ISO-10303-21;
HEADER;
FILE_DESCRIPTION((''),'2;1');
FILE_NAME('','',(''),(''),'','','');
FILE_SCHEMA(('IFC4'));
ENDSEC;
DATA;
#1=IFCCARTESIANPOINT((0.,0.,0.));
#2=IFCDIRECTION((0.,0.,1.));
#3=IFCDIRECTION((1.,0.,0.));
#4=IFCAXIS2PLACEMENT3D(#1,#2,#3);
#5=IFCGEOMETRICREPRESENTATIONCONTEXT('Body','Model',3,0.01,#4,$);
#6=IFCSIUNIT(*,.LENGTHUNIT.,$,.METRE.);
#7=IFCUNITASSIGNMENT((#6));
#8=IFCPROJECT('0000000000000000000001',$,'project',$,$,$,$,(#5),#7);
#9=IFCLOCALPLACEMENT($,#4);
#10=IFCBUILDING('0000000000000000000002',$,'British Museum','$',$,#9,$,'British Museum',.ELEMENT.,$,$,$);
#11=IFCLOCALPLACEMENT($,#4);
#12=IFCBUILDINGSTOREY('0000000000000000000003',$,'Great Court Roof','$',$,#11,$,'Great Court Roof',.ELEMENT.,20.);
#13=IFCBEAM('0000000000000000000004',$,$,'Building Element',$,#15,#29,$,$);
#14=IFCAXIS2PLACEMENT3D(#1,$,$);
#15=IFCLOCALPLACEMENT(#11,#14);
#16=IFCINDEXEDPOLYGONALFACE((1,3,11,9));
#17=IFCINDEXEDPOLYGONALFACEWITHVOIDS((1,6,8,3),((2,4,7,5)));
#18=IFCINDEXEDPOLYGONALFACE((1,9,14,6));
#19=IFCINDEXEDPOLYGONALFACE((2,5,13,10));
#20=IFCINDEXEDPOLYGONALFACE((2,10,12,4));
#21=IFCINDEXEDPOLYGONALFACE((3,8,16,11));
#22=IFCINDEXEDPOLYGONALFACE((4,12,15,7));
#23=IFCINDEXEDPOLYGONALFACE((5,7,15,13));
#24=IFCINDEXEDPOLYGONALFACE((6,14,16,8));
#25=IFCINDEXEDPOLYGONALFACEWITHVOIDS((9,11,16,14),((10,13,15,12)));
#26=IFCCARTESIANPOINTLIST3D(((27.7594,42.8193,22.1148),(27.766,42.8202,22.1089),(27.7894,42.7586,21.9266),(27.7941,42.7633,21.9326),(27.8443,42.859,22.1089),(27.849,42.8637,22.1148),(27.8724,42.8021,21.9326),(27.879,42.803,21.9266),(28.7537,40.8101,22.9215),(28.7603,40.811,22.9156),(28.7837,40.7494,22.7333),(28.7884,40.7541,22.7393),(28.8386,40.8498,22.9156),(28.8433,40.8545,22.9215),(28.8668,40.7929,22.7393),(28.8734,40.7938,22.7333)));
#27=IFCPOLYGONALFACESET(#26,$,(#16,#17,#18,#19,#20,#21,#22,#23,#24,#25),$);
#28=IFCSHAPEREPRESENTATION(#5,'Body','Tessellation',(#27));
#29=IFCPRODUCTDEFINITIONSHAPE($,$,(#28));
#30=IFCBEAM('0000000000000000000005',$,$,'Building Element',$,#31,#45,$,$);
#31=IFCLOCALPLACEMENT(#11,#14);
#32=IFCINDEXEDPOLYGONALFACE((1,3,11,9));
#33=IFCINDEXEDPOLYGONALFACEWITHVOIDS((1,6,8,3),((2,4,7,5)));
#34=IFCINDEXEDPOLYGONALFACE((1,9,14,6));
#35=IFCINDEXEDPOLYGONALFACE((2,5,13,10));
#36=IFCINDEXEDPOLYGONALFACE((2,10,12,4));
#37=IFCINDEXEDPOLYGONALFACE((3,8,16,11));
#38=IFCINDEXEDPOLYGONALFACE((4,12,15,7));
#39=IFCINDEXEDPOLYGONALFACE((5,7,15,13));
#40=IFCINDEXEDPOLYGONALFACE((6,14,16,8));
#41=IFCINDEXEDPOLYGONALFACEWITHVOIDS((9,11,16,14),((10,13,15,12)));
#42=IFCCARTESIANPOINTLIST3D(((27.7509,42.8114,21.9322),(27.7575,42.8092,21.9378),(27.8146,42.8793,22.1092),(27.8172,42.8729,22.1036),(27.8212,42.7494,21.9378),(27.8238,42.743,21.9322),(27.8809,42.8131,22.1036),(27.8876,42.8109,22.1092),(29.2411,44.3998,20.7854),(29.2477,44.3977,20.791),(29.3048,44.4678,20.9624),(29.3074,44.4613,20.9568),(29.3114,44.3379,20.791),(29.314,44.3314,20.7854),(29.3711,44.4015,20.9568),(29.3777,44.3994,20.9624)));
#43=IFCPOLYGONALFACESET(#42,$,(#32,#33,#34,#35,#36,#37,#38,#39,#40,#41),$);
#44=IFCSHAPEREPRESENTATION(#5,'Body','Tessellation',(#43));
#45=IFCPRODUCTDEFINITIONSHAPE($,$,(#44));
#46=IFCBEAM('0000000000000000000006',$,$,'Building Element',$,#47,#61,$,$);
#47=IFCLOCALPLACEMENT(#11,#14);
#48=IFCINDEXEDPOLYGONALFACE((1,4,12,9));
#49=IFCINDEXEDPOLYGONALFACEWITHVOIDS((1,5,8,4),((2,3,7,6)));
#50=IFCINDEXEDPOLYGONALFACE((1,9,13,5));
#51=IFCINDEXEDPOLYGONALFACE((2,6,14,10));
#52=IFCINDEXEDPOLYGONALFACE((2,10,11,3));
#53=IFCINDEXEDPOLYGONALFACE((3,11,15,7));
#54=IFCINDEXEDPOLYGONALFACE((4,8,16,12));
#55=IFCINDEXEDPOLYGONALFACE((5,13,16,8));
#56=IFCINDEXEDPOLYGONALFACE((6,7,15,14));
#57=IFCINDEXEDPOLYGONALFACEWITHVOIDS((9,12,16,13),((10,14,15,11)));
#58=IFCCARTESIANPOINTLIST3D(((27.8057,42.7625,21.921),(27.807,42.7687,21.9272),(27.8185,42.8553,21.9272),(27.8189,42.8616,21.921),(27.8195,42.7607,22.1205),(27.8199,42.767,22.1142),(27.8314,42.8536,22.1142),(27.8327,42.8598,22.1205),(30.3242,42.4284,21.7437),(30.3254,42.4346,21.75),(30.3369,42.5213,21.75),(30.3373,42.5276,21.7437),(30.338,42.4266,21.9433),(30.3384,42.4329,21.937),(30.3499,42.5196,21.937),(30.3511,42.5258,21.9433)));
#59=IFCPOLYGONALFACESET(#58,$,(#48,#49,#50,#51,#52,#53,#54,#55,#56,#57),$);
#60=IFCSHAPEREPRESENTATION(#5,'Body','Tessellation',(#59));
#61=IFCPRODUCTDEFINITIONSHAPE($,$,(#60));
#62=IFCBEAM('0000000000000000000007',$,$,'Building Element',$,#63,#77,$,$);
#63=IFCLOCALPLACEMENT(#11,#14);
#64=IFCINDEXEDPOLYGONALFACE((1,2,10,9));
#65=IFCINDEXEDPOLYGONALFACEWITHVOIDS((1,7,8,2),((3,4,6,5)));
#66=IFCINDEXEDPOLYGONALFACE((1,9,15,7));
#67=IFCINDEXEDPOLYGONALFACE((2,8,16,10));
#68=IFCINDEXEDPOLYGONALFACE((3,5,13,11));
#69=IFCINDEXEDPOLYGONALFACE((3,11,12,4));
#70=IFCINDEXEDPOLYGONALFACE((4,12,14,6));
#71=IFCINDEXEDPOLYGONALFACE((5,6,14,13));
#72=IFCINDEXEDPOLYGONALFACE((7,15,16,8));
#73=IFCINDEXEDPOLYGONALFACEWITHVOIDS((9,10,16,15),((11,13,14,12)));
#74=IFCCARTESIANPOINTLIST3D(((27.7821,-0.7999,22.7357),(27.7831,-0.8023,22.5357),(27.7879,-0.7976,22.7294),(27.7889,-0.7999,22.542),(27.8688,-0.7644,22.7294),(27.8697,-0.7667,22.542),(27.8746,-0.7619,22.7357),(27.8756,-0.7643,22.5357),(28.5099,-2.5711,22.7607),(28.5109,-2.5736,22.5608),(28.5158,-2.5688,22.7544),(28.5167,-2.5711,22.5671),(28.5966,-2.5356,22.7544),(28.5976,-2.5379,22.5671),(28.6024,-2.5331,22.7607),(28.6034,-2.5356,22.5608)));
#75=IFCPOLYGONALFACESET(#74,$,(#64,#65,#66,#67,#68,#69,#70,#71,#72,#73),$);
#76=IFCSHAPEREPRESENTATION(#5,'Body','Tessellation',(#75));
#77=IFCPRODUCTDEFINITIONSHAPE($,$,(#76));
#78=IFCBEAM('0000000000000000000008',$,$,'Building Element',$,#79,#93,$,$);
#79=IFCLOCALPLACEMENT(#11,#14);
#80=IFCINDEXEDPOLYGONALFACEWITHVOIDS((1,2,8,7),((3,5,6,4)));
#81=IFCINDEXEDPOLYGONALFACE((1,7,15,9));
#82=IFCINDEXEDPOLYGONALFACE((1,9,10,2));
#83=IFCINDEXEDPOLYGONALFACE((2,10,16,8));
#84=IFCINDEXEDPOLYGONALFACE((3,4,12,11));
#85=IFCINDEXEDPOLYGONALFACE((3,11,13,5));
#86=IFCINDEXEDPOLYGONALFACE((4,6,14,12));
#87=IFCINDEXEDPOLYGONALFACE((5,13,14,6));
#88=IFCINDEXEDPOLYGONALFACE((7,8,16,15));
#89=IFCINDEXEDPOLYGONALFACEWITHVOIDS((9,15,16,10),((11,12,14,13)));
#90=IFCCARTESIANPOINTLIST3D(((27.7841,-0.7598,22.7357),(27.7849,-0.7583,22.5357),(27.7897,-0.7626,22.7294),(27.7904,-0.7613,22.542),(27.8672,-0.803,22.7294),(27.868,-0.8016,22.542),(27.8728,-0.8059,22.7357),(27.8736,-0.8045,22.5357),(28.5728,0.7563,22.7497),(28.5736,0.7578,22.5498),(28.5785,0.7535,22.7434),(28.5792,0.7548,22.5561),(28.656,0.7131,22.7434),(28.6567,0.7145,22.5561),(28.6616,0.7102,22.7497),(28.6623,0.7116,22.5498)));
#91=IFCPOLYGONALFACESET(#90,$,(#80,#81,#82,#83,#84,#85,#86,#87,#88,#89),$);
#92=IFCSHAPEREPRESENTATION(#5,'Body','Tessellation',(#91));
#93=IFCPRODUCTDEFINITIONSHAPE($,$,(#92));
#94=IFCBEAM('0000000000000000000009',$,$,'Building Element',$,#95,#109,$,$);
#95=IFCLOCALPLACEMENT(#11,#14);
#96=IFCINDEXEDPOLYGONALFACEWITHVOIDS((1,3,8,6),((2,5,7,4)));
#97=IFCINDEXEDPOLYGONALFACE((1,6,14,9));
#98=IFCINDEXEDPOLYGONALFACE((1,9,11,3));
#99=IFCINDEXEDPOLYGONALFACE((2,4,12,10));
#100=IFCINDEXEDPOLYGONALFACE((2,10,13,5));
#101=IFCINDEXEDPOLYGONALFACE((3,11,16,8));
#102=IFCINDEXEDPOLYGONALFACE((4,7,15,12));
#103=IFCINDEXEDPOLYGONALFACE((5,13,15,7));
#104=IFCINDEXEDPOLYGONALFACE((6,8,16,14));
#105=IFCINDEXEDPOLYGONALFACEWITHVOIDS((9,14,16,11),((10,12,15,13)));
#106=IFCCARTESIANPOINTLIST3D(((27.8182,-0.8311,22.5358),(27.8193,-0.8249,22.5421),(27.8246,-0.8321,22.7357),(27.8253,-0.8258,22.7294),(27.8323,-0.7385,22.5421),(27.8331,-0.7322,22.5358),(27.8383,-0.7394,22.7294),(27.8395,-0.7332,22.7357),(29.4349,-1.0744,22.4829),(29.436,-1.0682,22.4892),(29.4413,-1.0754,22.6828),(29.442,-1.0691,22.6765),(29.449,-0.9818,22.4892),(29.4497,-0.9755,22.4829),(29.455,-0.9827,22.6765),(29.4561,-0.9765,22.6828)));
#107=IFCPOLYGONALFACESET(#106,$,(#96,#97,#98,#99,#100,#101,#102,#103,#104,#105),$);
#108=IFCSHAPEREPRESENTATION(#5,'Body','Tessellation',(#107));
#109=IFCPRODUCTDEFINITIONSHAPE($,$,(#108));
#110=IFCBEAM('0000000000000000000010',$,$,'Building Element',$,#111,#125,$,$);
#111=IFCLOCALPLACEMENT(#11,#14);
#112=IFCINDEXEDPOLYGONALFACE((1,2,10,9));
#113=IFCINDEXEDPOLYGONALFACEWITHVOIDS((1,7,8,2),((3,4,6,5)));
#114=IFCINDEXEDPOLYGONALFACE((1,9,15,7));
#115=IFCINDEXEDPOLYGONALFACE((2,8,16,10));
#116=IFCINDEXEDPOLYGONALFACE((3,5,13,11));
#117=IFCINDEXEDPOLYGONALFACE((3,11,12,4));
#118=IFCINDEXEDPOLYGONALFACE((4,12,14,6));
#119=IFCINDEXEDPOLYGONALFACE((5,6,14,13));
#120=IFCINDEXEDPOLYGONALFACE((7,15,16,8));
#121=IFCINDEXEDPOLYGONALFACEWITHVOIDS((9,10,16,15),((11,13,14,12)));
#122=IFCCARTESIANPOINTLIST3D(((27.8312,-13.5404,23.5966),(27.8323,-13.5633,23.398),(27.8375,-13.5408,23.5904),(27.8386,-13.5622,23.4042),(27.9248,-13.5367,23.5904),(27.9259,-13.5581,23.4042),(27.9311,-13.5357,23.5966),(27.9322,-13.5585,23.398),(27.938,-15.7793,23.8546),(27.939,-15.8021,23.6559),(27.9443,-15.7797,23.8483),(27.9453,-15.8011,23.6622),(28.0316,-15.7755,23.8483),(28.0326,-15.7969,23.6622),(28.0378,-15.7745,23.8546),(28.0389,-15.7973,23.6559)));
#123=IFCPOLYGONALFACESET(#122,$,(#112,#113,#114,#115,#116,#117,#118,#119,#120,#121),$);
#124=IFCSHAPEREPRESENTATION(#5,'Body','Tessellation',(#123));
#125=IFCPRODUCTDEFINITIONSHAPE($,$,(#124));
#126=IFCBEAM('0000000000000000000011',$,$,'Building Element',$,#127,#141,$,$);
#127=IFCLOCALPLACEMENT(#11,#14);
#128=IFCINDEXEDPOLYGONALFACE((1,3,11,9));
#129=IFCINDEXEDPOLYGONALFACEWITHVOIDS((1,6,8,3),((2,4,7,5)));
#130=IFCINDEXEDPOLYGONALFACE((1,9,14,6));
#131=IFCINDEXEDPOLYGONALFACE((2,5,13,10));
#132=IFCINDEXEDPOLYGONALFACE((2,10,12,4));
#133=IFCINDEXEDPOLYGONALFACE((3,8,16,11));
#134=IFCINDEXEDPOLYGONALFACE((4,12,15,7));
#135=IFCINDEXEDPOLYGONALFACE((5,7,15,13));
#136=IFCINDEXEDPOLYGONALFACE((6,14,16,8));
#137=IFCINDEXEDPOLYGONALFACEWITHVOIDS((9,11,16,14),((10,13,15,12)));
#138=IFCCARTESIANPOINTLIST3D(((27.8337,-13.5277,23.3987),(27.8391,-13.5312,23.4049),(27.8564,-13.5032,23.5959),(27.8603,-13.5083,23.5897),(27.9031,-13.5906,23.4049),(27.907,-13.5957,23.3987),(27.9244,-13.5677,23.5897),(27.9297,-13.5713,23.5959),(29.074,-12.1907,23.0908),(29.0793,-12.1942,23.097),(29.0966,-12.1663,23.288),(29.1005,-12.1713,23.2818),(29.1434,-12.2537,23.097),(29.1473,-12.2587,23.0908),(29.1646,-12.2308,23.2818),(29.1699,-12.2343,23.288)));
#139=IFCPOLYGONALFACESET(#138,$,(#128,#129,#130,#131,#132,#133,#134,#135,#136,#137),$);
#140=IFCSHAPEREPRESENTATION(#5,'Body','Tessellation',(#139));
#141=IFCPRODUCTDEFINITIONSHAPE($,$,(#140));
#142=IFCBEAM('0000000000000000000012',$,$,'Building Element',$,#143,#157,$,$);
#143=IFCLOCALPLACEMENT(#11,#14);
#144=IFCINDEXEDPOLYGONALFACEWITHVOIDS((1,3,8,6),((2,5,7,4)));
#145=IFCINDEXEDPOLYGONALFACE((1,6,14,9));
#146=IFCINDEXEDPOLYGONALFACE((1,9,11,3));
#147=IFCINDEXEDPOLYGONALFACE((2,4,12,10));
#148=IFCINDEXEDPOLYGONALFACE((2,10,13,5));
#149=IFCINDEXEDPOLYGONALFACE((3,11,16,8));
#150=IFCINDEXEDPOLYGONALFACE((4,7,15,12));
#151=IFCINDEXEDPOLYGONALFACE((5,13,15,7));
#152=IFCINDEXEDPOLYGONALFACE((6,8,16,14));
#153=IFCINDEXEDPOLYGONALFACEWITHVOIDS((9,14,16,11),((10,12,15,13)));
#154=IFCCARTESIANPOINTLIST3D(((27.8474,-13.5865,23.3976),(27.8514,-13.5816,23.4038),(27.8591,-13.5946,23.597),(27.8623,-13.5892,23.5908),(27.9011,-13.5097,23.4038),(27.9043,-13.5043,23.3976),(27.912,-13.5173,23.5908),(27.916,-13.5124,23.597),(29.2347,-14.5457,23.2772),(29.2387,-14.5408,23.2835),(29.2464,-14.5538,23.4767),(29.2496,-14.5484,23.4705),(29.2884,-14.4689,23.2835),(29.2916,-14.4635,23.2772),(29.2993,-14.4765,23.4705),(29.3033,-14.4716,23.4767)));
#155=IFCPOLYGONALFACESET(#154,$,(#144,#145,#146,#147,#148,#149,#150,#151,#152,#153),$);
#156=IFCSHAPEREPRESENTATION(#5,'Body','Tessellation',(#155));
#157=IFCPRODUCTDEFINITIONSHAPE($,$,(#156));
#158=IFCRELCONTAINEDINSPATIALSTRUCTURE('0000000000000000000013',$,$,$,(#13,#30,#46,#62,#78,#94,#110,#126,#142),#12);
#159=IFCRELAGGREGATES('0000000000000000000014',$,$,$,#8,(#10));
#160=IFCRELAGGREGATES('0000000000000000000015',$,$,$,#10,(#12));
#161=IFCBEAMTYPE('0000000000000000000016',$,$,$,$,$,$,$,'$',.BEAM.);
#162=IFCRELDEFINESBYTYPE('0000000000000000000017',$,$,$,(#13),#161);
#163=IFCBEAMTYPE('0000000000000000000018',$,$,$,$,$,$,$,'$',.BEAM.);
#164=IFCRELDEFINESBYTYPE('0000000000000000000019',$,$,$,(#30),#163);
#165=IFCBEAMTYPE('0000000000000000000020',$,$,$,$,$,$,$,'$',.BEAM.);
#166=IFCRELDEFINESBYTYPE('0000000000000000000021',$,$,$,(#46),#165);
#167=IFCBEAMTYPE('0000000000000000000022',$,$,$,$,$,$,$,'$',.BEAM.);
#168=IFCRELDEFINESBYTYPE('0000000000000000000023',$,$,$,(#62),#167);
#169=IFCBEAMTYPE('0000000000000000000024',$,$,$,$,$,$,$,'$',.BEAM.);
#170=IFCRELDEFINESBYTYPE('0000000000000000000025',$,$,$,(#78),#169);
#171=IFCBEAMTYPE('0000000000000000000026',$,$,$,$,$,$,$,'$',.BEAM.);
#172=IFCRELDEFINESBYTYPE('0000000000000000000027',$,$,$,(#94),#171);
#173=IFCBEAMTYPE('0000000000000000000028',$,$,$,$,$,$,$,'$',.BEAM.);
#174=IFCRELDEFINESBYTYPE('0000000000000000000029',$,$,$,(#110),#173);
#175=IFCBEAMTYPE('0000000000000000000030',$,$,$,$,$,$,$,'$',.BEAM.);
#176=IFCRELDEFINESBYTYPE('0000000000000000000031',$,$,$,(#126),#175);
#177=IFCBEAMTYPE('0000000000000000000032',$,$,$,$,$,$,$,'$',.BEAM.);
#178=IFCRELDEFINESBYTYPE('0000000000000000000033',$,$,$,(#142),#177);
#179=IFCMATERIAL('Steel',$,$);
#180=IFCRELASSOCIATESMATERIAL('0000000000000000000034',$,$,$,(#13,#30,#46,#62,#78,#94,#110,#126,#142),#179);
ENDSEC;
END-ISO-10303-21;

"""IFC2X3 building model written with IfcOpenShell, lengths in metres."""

from ifc_helpers import new_model, si_unit, frame, origin_with_axes, origin_2d, place, context, project, spatial, hollow_rectangle, extrude, material, type_object, element, save


model = new_model("IFC2X3")

# Units and contexts
model_context = context("Model", 3, precision=0.01, world=origin_with_axes(), identifier="Body")
ifc_project = project(units=[si_unit("LENGTHUNIT", "METRE")], contexts=[model_context])

# Building, storey
building_placement = place(None, origin_with_axes())
building = spatial("IfcBuilding", under=ifc_project, at=building_placement, Name="British Museum", Description="$", LongName="British Museum", CompositionType="ELEMENT")
storey_placement = place(None, origin_with_axes())
storey = spatial("IfcBuildingStorey", under=building, at=storey_placement, Name="Great Court Roof", Description="$", LongName="Great Court Roof", CompositionType="ELEMENT", Elevation=20.0)

# Beams
ifc_material = material(Name="Steel")
beam_type_1 = type_object("IfcBeamType", ElementType="$", PredefinedType="BEAM")
beam_1_placement = place(None, origin_with_axes())
element("IfcBeam", 1, at=beam_1_placement, inside=storey, type_object=beam_type_1, material=ifc_material, Description="Building Element", context=model_context, shape_type="SweptSolid", body=[
    extrude(hollow_rectangle(XDim=0.1, YDim=0.2, WallThickness=0.0063, InnerFilletRadius=-0.0063, OuterFilletRadius=0.0, at=origin_2d()), frame((27.8192, 42.8112, 22.0207), z_axis=(0.417342, -0.843313, 0.3386), x_axis=(0.896254, 0.443541, 0.0)), (0.0, 0.0, 1.0), 2.3825),
])
beam_type_2 = type_object("IfcBeamType", ElementType="$", PredefinedType="BEAM")
beam_2_placement = place(None, origin_with_axes())
element("IfcBeam", 2, at=beam_2_placement, inside=storey, type_object=beam_type_2, material=ifc_material, Description="Building Element", context=model_context, shape_type="SweptSolid", body=[
    extrude(hollow_rectangle(XDim=0.1, YDim=0.2, WallThickness=0.0063, InnerFilletRadius=-0.0063, OuterFilletRadius=0.0, at=origin_2d()), frame((27.8192, 42.8112, 22.0207), z_axis=(0.605403, 0.645311, -0.465897), x_axis=(-0.729298, 0.684196, 0.0)), (0.0, 0.0, 1.0), 2.4615),
])
beam_type_3 = type_object("IfcBeamType", ElementType="$", PredefinedType="BEAM")
beam_3_placement = place(None, origin_with_axes())
element("IfcBeam", 3, at=beam_3_placement, inside=storey, type_object=beam_type_3, material=ifc_material, Description="Building Element", context=model_context, shape_type="SweptSolid", body=[
    extrude(hollow_rectangle(XDim=0.1, YDim=0.2, WallThickness=0.0063, InnerFilletRadius=-0.0063, OuterFilletRadius=0.0, at=origin_2d()), frame((27.8192, 42.8112, 22.0207), z_axis=(0.988914, -0.131176, -0.069585), x_axis=(0.131495, 0.991317, 0.0)), (0.0, 0.0, 1.0), 2.5467),
])
beam_type_4 = type_object("IfcBeamType", ElementType="$", PredefinedType="BEAM")
beam_4_placement = place(None, origin_with_axes())
element("IfcBeam", 4, at=beam_4_placement, inside=storey, type_object=beam_type_4, material=ifc_material, Description="Building Element", context=model_context, shape_type="SweptSolid", body=[
    extrude(hollow_rectangle(XDim=0.1, YDim=0.2, WallThickness=0.0063, InnerFilletRadius=-0.0063, OuterFilletRadius=0.0, at=origin_2d()), frame((27.8288, -0.7821, 22.6357), z_axis=(0.380058, -0.924871, 0.013065), x_axis=(0.92495, 0.38009, 0.0)), (0.0, 0.0, 1.0), 1.9151),
])
beam_type_5 = type_object("IfcBeamType", ElementType="$", PredefinedType="BEAM")
beam_5_placement = place(None, origin_with_axes())
element("IfcBeam", 5, at=beam_5_placement, inside=storey, type_object=beam_type_5, material=ifc_material, Description="Building Element", context=model_context, shape_type="SweptSolid", body=[
    extrude(hollow_rectangle(XDim=0.1, YDim=0.2, WallThickness=0.0063, InnerFilletRadius=-0.0063, OuterFilletRadius=0.0, at=origin_2d()), frame((27.8288, -0.7821, 22.6357), z_axis=(0.461507, 0.887099, 0.008202), x_axis=(-0.887129, 0.461522, 0.0)), (0.0, 0.0, 1.0), 1.7091),
])
beam_type_6 = type_object("IfcBeamType", ElementType="$", PredefinedType="BEAM")
beam_6_placement = place(None, origin_with_axes())
element("IfcBeam", 6, at=beam_6_placement, inside=storey, type_object=beam_type_6, material=ifc_material, Description="Building Element", context=model_context, shape_type="SweptSolid", body=[
    extrude(hollow_rectangle(XDim=0.1, YDim=0.2, WallThickness=0.0063, InnerFilletRadius=-0.0063, OuterFilletRadius=0.0, at=origin_2d()), frame((27.8288, -0.7821, 22.6357), z_axis=(0.988348, -0.148741, -0.032315), x_axis=(0.148818, 0.988865, 0.0)), (0.0, 0.0, 1.0), 1.6357),
])
beam_type_7 = type_object("IfcBeamType", ElementType="$", PredefinedType="BEAM")
beam_7_placement = place(None, origin_with_axes())
element("IfcBeam", 7, at=beam_7_placement, inside=storey, type_object=beam_type_7, material=ifc_material, Description="Building Element", context=model_context, shape_type="SweptSolid", body=[
    extrude(hollow_rectangle(XDim=0.1, YDim=0.2, WallThickness=0.0063, InnerFilletRadius=-0.0063, OuterFilletRadius=0.0, at=origin_2d()), frame((27.8817, -13.5495, 23.4973), z_axis=(0.047308, -0.992316, 0.114327), x_axis=(0.998866, 0.04762, 0.0)), (0.0, 0.0, 1.0), 2.2562),
])
beam_type_8 = type_object("IfcBeamType", ElementType="$", PredefinedType="BEAM")
beam_8_placement = place(None, origin_with_axes())
element("IfcBeam", 8, at=beam_8_placement, inside=storey, type_object=beam_type_8, material=ifc_material, Description="Building Element", context=model_context, shape_type="SweptSolid", body=[
    extrude(hollow_rectangle(XDim=0.1, YDim=0.2, WallThickness=0.0063, InnerFilletRadius=-0.0063, OuterFilletRadius=0.0, at=origin_2d()), frame((27.8817, -13.5495, 23.4973), z_axis=(0.6706, 0.722891, -0.166504), x_axis=(-0.733125, 0.680094, 0.0)), (0.0, 0.0, 1.0), 1.8495),
])
beam_type_9 = type_object("IfcBeamType", ElementType="$", PredefinedType="BEAM")
beam_9_placement = place(None, origin_with_axes())
element("IfcBeam", 9, at=beam_9_placement, inside=storey, type_object=beam_type_9, material=ifc_material, Description="Building Element", context=model_context, shape_type="SweptSolid", body=[
    extrude(hollow_rectangle(XDim=0.1, YDim=0.2, WallThickness=0.0063, InnerFilletRadius=-0.0063, OuterFilletRadius=0.0, at=origin_2d()), frame((27.8817, -13.5495, 23.4973), z_axis=(0.820452, -0.56727, -0.071151), x_axis=(0.568712, 0.822537, 0.0)), (0.0, 0.0, 1.0), 1.6909),
])

save(model, "model.ifc")
